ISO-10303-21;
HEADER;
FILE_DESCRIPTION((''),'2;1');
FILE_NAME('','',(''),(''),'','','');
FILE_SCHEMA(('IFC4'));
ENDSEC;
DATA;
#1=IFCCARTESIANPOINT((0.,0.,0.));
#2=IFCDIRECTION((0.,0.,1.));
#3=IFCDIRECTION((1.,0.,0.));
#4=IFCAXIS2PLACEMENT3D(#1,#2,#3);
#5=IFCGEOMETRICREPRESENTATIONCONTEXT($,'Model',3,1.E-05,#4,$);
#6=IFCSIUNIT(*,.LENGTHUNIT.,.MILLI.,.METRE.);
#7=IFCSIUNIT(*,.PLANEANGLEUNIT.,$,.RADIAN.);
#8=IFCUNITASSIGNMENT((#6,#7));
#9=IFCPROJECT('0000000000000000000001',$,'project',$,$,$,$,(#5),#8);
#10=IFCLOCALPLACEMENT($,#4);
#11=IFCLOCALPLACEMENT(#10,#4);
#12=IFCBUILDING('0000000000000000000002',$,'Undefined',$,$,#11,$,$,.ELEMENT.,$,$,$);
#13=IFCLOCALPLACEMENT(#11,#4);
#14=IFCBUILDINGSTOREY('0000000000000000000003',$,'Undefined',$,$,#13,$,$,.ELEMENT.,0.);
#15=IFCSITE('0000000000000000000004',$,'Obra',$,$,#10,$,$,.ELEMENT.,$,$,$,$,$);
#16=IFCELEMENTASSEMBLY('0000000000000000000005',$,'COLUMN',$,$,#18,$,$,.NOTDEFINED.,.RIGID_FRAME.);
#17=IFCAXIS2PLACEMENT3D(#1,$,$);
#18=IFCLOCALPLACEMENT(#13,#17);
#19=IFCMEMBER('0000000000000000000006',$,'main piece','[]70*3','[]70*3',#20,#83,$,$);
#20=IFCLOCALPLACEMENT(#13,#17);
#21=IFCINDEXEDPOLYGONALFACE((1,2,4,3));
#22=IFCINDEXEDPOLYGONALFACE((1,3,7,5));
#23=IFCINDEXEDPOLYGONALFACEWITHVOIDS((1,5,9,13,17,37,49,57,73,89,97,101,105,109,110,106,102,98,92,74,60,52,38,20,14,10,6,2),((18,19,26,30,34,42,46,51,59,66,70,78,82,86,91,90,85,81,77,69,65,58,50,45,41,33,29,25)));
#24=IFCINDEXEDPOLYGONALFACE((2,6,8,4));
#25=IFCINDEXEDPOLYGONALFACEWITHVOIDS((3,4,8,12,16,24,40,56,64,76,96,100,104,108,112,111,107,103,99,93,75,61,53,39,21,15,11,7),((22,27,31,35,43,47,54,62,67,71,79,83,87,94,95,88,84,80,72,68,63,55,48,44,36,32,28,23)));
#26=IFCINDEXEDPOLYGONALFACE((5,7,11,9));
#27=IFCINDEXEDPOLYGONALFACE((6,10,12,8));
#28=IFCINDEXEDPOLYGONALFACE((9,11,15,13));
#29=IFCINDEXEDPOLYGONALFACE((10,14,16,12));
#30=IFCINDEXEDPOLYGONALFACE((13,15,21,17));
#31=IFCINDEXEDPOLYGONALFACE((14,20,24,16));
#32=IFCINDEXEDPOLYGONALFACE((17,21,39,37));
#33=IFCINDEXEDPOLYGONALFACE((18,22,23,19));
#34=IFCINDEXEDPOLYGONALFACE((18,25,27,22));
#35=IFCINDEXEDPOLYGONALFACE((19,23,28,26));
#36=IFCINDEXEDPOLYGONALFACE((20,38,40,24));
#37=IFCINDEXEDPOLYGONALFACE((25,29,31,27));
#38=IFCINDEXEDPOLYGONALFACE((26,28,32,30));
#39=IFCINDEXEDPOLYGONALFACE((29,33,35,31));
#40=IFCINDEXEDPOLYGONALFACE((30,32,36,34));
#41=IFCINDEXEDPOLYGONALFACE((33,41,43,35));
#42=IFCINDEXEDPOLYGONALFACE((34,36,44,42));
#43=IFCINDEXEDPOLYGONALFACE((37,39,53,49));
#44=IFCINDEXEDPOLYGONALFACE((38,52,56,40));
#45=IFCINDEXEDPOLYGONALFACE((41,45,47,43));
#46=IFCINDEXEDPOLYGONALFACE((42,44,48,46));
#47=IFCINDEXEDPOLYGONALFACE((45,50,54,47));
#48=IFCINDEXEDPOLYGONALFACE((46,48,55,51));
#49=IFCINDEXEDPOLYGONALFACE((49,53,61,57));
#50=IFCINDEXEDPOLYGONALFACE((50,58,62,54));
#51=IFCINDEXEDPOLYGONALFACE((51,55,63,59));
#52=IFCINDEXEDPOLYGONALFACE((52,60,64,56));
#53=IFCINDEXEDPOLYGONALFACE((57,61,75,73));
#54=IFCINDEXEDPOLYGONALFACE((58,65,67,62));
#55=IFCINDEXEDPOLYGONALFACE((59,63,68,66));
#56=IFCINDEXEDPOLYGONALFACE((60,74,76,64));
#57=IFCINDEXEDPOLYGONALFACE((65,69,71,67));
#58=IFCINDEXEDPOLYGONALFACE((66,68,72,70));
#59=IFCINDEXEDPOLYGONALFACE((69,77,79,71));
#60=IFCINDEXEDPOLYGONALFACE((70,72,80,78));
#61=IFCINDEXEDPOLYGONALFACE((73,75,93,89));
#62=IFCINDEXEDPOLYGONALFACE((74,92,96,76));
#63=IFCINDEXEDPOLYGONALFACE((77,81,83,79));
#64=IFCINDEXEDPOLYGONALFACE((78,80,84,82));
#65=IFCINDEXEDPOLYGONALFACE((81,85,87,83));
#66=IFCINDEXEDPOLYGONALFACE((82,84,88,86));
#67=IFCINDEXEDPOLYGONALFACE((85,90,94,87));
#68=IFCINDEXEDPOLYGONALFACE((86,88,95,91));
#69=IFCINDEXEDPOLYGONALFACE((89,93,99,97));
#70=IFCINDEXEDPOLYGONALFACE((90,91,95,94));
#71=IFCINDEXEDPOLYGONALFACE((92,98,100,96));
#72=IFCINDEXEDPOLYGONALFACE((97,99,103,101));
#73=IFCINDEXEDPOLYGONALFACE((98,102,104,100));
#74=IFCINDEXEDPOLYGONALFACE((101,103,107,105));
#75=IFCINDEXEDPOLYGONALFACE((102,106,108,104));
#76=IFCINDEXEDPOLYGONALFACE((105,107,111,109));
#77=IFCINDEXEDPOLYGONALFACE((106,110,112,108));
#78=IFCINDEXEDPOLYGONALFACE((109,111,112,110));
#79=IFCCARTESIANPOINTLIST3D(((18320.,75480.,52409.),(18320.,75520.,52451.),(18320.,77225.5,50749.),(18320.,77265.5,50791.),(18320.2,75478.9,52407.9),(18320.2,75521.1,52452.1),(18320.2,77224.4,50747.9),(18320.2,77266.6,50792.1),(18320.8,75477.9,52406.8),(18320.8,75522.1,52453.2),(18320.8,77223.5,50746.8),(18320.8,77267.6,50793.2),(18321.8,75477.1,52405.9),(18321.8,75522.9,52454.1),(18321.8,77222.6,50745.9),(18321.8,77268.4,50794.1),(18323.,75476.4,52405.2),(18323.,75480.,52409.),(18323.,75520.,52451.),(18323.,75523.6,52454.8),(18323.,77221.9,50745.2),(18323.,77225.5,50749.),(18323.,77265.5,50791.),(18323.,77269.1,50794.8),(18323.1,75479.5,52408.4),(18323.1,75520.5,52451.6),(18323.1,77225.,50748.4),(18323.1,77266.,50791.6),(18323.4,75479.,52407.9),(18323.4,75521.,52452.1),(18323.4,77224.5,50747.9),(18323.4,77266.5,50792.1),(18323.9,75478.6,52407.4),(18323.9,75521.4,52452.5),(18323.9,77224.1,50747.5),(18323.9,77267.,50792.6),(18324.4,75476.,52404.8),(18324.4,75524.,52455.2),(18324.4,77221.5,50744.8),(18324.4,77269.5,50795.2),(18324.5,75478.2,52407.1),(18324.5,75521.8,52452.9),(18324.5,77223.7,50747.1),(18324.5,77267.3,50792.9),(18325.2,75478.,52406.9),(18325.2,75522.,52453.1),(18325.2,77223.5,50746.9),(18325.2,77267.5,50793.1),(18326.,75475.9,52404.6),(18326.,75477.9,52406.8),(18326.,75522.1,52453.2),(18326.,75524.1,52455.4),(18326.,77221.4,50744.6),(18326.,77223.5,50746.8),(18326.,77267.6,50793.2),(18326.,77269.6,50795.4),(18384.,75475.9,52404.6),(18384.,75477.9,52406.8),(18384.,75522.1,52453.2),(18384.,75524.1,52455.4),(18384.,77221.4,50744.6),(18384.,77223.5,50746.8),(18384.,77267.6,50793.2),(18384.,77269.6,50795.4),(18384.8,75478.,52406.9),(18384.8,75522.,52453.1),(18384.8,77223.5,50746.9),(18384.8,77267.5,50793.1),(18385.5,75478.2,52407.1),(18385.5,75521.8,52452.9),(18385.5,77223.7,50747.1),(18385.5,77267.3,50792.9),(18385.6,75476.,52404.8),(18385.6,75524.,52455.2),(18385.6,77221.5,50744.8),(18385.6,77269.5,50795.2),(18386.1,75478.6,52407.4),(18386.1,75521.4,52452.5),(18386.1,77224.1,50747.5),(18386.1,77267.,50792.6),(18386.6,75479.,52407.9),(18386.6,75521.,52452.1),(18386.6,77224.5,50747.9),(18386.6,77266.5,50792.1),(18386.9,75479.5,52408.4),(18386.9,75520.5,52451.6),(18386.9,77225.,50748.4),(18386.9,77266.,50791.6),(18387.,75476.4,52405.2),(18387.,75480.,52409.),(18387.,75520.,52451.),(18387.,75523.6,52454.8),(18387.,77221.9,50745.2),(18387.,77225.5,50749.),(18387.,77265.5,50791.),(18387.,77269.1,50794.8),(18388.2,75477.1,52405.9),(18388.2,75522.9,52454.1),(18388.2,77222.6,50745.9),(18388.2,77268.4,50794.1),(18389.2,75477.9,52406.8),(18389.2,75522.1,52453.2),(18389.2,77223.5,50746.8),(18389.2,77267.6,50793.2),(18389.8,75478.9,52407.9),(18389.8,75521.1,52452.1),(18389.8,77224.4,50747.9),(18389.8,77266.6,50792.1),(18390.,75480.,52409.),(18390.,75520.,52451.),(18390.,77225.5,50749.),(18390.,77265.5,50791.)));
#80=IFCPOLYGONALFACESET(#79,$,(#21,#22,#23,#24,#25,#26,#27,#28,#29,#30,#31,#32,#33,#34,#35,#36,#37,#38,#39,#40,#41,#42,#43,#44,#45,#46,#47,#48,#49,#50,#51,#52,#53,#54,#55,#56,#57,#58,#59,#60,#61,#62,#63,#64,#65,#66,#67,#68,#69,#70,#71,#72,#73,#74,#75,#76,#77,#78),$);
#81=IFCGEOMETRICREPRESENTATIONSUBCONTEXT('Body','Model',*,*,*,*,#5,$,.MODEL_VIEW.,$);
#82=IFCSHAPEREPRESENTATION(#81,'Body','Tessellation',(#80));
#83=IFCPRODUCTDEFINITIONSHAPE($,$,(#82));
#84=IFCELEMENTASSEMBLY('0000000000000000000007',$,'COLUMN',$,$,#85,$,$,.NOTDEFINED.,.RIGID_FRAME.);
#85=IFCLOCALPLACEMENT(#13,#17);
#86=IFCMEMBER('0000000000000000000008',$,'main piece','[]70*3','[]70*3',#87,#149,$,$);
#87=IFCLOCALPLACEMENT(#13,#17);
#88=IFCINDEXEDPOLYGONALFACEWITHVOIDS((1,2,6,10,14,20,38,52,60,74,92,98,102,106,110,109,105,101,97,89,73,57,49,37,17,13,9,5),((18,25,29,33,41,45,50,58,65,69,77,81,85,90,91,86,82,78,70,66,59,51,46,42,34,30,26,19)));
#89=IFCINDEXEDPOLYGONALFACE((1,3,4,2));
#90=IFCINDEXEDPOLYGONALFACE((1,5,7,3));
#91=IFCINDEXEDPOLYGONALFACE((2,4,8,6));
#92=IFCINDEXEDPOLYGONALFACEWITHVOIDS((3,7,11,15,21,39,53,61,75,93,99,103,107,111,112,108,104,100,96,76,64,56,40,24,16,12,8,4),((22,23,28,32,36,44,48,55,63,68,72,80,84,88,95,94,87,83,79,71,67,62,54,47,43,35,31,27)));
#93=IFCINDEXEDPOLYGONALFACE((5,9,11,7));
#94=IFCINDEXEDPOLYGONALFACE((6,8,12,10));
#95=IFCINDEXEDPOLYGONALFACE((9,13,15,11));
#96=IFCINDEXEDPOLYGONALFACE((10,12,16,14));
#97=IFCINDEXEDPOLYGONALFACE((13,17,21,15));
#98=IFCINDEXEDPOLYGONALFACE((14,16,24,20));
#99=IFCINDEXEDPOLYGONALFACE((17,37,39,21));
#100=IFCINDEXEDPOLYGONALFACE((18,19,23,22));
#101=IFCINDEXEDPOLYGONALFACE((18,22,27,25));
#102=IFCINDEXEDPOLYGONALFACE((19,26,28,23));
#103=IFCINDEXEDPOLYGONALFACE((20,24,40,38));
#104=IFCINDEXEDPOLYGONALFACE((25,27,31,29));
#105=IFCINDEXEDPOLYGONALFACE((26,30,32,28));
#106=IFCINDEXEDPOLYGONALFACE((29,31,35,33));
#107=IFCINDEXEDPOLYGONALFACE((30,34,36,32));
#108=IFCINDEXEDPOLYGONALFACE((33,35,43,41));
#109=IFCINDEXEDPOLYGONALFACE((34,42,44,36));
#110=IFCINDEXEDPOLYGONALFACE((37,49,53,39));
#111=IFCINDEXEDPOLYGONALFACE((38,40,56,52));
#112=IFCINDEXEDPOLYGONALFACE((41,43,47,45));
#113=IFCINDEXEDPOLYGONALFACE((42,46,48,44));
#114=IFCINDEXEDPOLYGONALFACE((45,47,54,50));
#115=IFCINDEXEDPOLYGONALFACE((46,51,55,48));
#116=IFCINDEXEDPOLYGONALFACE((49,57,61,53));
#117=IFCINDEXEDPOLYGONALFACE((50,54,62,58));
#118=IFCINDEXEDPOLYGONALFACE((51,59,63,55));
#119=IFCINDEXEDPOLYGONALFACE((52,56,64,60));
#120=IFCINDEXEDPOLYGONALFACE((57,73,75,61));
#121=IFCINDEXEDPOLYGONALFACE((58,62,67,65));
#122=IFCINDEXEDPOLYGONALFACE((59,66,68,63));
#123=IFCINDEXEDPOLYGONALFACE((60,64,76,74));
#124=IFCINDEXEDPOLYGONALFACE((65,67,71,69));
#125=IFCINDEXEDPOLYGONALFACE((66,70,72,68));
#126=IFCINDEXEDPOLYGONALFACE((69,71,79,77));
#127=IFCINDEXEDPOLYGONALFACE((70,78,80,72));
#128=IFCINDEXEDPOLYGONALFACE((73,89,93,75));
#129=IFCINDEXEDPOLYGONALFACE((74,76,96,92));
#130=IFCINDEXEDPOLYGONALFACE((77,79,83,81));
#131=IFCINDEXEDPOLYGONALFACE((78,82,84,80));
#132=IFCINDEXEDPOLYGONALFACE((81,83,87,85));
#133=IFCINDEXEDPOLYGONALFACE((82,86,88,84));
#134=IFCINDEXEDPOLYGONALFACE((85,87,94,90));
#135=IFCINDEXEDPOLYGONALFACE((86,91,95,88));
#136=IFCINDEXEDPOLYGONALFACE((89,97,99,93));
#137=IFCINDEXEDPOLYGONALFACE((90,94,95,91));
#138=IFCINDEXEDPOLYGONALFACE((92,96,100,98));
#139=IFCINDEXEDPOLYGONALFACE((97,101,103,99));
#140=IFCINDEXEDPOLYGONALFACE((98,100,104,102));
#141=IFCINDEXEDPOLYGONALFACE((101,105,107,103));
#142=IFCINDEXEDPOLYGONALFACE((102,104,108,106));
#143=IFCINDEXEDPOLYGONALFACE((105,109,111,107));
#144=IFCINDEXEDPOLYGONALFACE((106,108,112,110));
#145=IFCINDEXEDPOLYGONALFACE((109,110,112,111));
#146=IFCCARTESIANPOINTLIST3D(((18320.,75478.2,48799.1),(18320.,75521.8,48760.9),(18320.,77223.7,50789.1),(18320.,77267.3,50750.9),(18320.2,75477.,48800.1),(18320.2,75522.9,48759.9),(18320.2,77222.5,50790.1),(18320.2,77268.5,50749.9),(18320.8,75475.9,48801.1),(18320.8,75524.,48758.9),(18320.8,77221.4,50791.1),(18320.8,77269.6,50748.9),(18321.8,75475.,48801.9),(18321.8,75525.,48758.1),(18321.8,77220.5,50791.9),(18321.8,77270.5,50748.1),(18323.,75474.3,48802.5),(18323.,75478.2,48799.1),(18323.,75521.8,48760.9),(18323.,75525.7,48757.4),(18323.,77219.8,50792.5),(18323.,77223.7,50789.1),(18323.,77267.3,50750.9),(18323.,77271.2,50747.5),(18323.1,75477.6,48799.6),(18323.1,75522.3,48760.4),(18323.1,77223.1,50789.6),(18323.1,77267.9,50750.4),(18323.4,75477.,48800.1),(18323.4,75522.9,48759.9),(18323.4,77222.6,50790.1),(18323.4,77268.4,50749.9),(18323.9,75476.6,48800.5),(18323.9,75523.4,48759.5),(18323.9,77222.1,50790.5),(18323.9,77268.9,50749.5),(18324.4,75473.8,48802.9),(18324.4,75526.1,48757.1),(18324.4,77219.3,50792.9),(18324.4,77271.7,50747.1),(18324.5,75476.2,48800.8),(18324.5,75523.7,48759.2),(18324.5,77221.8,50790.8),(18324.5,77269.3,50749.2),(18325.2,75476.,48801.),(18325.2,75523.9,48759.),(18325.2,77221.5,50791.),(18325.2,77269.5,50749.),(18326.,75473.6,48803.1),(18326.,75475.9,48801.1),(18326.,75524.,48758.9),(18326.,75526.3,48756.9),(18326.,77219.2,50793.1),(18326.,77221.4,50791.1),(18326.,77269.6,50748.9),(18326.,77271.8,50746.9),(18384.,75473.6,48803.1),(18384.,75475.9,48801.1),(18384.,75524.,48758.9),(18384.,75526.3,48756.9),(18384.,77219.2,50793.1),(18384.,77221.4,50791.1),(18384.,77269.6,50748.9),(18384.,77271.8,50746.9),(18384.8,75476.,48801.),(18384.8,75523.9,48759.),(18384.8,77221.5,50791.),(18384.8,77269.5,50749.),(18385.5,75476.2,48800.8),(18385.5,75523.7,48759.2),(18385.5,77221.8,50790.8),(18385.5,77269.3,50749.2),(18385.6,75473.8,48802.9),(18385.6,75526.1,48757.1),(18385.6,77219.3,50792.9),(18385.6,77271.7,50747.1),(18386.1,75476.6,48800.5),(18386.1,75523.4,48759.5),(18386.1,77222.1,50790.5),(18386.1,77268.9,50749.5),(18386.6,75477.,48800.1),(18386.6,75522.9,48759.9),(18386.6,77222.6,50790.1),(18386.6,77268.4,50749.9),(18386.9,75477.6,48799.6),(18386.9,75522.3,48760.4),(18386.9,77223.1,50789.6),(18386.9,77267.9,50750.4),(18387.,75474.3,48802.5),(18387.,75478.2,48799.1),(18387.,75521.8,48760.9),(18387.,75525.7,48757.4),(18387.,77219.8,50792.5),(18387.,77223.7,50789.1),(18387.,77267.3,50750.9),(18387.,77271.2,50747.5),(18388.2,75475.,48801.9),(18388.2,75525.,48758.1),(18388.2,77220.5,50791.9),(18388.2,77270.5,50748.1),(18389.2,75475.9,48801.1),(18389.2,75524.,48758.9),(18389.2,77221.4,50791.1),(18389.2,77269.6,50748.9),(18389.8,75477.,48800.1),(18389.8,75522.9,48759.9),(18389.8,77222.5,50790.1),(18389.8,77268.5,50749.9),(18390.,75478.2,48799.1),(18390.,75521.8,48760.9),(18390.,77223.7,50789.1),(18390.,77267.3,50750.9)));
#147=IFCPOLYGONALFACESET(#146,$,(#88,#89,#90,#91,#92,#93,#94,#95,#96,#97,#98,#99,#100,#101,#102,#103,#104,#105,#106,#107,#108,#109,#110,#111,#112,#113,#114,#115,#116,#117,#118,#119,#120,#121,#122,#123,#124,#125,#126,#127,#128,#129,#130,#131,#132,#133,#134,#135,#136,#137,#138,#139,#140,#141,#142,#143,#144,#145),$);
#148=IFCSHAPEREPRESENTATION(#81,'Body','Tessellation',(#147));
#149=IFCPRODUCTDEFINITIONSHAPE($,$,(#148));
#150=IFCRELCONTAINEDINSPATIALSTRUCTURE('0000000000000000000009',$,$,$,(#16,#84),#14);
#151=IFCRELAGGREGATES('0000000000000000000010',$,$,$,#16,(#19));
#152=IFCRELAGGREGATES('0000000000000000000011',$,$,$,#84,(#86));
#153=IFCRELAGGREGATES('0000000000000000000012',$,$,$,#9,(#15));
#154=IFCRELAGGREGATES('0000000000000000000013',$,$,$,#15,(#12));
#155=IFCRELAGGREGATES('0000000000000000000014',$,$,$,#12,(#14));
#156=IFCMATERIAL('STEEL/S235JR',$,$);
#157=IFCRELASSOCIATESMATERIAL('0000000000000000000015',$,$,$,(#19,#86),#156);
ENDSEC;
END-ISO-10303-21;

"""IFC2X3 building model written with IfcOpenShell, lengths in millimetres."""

from ifc_helpers import new_model, si_unit, frame, origin_with_axes, origin_2d_with_axis, place, context, subcontext, project, spatial, hollow_rectangle, extrude, material, element, aggregate, save


model = new_model("IFC2X3")

# Units and contexts
model_context = context("Model", 3, precision=1e-05, world=origin_with_axes())
body_context = subcontext(model_context, "Body", "Model", "MODEL_VIEW")
ifc_project = project(units=[si_unit("LENGTHUNIT", "METRE", prefix="MILLI"), si_unit("PLANEANGLEUNIT", "RADIAN")], contexts=[model_context])

# Site, building, storey
site_placement = place(None, origin_with_axes())
site = spatial("IfcSite", under=ifc_project, at=site_placement, Name="Obra", CompositionType="ELEMENT")
building_placement = place(site_placement, origin_with_axes())
building = spatial("IfcBuilding", under=site, at=building_placement, Name="Undefined", CompositionType="ELEMENT")
storey_placement = place(building_placement, origin_with_axes())
storey = spatial("IfcBuildingStorey", under=building, at=storey_placement, Name="Undefined", CompositionType="ELEMENT", Elevation=0.0)

# Shared definitions
ifc_material = material(Name="STEEL/S235JR")

# Element assemblies, members
assembly_1_placement = place(storey_placement, origin_with_axes())
assembly_1 = element("IfcElementAssembly", 1, at=assembly_1_placement, inside=storey, Name="COLUMN", AssemblyPlace="NOTDEFINED", PredefinedType="RIGID_FRAME")
member_1_placement = place(assembly_1_placement, frame((18355.0, 77245.5, 50770.0), z_axis=(1.0, 0.0, 0.0), x_axis=(0.0, -0.724633, 0.689135)))
member_1 = element("IfcMember", 2, at=member_1_placement, material=ifc_material, Name="main piece", Description="[]70*3", ObjectType="[]70*3", context=body_context, shape_type="SweptSolid", body=[
    extrude(hollow_rectangle(XDim=70.0, YDim=70.0, WallThickness=3.0, InnerFilletRadius=3.0, OuterFilletRadius=6.0, at=origin_2d_with_axis()), frame((2408.8, 0.0, 0.0), z_axis=(-1.0, 0.0, 0.0), x_axis=(0.0, -1.0, 0.0)), (0.0, 0.0, 1.0), 2408.8),
])
aggregate(assembly_1, [member_1])
assembly_2_placement = place(storey_placement, origin_with_axes())
assembly_2 = element("IfcElementAssembly", 3, at=assembly_2_placement, inside=storey, Name="COLUMN", AssemblyPlace="NOTDEFINED", PredefinedType="RIGID_FRAME")
member_2_placement = place(assembly_2_placement, frame((18355.0, 75500.0, 48780.0), z_axis=(-1.0, 0.0, 0.0), x_axis=(0.0, 0.659423, 0.751772)))
member_2 = element("IfcMember", 4, at=member_2_placement, material=ifc_material, Name="main piece", Description="[]70*3", ObjectType="[]70*3", context=body_context, shape_type="SweptSolid", body=[
    extrude(hollow_rectangle(XDim=70.0, YDim=70.0, WallThickness=3.0, InnerFilletRadius=3.0, OuterFilletRadius=6.0, at=origin_2d_with_axis()), frame((2647.1, 0.0, 0.0), z_axis=(-1.0, 0.0, 0.0), x_axis=(0.0, -1.0, 0.0)), (0.0, 0.0, 1.0), 2647.1),
])
aggregate(assembly_2, [member_2])

save(model, "model.ifc")
